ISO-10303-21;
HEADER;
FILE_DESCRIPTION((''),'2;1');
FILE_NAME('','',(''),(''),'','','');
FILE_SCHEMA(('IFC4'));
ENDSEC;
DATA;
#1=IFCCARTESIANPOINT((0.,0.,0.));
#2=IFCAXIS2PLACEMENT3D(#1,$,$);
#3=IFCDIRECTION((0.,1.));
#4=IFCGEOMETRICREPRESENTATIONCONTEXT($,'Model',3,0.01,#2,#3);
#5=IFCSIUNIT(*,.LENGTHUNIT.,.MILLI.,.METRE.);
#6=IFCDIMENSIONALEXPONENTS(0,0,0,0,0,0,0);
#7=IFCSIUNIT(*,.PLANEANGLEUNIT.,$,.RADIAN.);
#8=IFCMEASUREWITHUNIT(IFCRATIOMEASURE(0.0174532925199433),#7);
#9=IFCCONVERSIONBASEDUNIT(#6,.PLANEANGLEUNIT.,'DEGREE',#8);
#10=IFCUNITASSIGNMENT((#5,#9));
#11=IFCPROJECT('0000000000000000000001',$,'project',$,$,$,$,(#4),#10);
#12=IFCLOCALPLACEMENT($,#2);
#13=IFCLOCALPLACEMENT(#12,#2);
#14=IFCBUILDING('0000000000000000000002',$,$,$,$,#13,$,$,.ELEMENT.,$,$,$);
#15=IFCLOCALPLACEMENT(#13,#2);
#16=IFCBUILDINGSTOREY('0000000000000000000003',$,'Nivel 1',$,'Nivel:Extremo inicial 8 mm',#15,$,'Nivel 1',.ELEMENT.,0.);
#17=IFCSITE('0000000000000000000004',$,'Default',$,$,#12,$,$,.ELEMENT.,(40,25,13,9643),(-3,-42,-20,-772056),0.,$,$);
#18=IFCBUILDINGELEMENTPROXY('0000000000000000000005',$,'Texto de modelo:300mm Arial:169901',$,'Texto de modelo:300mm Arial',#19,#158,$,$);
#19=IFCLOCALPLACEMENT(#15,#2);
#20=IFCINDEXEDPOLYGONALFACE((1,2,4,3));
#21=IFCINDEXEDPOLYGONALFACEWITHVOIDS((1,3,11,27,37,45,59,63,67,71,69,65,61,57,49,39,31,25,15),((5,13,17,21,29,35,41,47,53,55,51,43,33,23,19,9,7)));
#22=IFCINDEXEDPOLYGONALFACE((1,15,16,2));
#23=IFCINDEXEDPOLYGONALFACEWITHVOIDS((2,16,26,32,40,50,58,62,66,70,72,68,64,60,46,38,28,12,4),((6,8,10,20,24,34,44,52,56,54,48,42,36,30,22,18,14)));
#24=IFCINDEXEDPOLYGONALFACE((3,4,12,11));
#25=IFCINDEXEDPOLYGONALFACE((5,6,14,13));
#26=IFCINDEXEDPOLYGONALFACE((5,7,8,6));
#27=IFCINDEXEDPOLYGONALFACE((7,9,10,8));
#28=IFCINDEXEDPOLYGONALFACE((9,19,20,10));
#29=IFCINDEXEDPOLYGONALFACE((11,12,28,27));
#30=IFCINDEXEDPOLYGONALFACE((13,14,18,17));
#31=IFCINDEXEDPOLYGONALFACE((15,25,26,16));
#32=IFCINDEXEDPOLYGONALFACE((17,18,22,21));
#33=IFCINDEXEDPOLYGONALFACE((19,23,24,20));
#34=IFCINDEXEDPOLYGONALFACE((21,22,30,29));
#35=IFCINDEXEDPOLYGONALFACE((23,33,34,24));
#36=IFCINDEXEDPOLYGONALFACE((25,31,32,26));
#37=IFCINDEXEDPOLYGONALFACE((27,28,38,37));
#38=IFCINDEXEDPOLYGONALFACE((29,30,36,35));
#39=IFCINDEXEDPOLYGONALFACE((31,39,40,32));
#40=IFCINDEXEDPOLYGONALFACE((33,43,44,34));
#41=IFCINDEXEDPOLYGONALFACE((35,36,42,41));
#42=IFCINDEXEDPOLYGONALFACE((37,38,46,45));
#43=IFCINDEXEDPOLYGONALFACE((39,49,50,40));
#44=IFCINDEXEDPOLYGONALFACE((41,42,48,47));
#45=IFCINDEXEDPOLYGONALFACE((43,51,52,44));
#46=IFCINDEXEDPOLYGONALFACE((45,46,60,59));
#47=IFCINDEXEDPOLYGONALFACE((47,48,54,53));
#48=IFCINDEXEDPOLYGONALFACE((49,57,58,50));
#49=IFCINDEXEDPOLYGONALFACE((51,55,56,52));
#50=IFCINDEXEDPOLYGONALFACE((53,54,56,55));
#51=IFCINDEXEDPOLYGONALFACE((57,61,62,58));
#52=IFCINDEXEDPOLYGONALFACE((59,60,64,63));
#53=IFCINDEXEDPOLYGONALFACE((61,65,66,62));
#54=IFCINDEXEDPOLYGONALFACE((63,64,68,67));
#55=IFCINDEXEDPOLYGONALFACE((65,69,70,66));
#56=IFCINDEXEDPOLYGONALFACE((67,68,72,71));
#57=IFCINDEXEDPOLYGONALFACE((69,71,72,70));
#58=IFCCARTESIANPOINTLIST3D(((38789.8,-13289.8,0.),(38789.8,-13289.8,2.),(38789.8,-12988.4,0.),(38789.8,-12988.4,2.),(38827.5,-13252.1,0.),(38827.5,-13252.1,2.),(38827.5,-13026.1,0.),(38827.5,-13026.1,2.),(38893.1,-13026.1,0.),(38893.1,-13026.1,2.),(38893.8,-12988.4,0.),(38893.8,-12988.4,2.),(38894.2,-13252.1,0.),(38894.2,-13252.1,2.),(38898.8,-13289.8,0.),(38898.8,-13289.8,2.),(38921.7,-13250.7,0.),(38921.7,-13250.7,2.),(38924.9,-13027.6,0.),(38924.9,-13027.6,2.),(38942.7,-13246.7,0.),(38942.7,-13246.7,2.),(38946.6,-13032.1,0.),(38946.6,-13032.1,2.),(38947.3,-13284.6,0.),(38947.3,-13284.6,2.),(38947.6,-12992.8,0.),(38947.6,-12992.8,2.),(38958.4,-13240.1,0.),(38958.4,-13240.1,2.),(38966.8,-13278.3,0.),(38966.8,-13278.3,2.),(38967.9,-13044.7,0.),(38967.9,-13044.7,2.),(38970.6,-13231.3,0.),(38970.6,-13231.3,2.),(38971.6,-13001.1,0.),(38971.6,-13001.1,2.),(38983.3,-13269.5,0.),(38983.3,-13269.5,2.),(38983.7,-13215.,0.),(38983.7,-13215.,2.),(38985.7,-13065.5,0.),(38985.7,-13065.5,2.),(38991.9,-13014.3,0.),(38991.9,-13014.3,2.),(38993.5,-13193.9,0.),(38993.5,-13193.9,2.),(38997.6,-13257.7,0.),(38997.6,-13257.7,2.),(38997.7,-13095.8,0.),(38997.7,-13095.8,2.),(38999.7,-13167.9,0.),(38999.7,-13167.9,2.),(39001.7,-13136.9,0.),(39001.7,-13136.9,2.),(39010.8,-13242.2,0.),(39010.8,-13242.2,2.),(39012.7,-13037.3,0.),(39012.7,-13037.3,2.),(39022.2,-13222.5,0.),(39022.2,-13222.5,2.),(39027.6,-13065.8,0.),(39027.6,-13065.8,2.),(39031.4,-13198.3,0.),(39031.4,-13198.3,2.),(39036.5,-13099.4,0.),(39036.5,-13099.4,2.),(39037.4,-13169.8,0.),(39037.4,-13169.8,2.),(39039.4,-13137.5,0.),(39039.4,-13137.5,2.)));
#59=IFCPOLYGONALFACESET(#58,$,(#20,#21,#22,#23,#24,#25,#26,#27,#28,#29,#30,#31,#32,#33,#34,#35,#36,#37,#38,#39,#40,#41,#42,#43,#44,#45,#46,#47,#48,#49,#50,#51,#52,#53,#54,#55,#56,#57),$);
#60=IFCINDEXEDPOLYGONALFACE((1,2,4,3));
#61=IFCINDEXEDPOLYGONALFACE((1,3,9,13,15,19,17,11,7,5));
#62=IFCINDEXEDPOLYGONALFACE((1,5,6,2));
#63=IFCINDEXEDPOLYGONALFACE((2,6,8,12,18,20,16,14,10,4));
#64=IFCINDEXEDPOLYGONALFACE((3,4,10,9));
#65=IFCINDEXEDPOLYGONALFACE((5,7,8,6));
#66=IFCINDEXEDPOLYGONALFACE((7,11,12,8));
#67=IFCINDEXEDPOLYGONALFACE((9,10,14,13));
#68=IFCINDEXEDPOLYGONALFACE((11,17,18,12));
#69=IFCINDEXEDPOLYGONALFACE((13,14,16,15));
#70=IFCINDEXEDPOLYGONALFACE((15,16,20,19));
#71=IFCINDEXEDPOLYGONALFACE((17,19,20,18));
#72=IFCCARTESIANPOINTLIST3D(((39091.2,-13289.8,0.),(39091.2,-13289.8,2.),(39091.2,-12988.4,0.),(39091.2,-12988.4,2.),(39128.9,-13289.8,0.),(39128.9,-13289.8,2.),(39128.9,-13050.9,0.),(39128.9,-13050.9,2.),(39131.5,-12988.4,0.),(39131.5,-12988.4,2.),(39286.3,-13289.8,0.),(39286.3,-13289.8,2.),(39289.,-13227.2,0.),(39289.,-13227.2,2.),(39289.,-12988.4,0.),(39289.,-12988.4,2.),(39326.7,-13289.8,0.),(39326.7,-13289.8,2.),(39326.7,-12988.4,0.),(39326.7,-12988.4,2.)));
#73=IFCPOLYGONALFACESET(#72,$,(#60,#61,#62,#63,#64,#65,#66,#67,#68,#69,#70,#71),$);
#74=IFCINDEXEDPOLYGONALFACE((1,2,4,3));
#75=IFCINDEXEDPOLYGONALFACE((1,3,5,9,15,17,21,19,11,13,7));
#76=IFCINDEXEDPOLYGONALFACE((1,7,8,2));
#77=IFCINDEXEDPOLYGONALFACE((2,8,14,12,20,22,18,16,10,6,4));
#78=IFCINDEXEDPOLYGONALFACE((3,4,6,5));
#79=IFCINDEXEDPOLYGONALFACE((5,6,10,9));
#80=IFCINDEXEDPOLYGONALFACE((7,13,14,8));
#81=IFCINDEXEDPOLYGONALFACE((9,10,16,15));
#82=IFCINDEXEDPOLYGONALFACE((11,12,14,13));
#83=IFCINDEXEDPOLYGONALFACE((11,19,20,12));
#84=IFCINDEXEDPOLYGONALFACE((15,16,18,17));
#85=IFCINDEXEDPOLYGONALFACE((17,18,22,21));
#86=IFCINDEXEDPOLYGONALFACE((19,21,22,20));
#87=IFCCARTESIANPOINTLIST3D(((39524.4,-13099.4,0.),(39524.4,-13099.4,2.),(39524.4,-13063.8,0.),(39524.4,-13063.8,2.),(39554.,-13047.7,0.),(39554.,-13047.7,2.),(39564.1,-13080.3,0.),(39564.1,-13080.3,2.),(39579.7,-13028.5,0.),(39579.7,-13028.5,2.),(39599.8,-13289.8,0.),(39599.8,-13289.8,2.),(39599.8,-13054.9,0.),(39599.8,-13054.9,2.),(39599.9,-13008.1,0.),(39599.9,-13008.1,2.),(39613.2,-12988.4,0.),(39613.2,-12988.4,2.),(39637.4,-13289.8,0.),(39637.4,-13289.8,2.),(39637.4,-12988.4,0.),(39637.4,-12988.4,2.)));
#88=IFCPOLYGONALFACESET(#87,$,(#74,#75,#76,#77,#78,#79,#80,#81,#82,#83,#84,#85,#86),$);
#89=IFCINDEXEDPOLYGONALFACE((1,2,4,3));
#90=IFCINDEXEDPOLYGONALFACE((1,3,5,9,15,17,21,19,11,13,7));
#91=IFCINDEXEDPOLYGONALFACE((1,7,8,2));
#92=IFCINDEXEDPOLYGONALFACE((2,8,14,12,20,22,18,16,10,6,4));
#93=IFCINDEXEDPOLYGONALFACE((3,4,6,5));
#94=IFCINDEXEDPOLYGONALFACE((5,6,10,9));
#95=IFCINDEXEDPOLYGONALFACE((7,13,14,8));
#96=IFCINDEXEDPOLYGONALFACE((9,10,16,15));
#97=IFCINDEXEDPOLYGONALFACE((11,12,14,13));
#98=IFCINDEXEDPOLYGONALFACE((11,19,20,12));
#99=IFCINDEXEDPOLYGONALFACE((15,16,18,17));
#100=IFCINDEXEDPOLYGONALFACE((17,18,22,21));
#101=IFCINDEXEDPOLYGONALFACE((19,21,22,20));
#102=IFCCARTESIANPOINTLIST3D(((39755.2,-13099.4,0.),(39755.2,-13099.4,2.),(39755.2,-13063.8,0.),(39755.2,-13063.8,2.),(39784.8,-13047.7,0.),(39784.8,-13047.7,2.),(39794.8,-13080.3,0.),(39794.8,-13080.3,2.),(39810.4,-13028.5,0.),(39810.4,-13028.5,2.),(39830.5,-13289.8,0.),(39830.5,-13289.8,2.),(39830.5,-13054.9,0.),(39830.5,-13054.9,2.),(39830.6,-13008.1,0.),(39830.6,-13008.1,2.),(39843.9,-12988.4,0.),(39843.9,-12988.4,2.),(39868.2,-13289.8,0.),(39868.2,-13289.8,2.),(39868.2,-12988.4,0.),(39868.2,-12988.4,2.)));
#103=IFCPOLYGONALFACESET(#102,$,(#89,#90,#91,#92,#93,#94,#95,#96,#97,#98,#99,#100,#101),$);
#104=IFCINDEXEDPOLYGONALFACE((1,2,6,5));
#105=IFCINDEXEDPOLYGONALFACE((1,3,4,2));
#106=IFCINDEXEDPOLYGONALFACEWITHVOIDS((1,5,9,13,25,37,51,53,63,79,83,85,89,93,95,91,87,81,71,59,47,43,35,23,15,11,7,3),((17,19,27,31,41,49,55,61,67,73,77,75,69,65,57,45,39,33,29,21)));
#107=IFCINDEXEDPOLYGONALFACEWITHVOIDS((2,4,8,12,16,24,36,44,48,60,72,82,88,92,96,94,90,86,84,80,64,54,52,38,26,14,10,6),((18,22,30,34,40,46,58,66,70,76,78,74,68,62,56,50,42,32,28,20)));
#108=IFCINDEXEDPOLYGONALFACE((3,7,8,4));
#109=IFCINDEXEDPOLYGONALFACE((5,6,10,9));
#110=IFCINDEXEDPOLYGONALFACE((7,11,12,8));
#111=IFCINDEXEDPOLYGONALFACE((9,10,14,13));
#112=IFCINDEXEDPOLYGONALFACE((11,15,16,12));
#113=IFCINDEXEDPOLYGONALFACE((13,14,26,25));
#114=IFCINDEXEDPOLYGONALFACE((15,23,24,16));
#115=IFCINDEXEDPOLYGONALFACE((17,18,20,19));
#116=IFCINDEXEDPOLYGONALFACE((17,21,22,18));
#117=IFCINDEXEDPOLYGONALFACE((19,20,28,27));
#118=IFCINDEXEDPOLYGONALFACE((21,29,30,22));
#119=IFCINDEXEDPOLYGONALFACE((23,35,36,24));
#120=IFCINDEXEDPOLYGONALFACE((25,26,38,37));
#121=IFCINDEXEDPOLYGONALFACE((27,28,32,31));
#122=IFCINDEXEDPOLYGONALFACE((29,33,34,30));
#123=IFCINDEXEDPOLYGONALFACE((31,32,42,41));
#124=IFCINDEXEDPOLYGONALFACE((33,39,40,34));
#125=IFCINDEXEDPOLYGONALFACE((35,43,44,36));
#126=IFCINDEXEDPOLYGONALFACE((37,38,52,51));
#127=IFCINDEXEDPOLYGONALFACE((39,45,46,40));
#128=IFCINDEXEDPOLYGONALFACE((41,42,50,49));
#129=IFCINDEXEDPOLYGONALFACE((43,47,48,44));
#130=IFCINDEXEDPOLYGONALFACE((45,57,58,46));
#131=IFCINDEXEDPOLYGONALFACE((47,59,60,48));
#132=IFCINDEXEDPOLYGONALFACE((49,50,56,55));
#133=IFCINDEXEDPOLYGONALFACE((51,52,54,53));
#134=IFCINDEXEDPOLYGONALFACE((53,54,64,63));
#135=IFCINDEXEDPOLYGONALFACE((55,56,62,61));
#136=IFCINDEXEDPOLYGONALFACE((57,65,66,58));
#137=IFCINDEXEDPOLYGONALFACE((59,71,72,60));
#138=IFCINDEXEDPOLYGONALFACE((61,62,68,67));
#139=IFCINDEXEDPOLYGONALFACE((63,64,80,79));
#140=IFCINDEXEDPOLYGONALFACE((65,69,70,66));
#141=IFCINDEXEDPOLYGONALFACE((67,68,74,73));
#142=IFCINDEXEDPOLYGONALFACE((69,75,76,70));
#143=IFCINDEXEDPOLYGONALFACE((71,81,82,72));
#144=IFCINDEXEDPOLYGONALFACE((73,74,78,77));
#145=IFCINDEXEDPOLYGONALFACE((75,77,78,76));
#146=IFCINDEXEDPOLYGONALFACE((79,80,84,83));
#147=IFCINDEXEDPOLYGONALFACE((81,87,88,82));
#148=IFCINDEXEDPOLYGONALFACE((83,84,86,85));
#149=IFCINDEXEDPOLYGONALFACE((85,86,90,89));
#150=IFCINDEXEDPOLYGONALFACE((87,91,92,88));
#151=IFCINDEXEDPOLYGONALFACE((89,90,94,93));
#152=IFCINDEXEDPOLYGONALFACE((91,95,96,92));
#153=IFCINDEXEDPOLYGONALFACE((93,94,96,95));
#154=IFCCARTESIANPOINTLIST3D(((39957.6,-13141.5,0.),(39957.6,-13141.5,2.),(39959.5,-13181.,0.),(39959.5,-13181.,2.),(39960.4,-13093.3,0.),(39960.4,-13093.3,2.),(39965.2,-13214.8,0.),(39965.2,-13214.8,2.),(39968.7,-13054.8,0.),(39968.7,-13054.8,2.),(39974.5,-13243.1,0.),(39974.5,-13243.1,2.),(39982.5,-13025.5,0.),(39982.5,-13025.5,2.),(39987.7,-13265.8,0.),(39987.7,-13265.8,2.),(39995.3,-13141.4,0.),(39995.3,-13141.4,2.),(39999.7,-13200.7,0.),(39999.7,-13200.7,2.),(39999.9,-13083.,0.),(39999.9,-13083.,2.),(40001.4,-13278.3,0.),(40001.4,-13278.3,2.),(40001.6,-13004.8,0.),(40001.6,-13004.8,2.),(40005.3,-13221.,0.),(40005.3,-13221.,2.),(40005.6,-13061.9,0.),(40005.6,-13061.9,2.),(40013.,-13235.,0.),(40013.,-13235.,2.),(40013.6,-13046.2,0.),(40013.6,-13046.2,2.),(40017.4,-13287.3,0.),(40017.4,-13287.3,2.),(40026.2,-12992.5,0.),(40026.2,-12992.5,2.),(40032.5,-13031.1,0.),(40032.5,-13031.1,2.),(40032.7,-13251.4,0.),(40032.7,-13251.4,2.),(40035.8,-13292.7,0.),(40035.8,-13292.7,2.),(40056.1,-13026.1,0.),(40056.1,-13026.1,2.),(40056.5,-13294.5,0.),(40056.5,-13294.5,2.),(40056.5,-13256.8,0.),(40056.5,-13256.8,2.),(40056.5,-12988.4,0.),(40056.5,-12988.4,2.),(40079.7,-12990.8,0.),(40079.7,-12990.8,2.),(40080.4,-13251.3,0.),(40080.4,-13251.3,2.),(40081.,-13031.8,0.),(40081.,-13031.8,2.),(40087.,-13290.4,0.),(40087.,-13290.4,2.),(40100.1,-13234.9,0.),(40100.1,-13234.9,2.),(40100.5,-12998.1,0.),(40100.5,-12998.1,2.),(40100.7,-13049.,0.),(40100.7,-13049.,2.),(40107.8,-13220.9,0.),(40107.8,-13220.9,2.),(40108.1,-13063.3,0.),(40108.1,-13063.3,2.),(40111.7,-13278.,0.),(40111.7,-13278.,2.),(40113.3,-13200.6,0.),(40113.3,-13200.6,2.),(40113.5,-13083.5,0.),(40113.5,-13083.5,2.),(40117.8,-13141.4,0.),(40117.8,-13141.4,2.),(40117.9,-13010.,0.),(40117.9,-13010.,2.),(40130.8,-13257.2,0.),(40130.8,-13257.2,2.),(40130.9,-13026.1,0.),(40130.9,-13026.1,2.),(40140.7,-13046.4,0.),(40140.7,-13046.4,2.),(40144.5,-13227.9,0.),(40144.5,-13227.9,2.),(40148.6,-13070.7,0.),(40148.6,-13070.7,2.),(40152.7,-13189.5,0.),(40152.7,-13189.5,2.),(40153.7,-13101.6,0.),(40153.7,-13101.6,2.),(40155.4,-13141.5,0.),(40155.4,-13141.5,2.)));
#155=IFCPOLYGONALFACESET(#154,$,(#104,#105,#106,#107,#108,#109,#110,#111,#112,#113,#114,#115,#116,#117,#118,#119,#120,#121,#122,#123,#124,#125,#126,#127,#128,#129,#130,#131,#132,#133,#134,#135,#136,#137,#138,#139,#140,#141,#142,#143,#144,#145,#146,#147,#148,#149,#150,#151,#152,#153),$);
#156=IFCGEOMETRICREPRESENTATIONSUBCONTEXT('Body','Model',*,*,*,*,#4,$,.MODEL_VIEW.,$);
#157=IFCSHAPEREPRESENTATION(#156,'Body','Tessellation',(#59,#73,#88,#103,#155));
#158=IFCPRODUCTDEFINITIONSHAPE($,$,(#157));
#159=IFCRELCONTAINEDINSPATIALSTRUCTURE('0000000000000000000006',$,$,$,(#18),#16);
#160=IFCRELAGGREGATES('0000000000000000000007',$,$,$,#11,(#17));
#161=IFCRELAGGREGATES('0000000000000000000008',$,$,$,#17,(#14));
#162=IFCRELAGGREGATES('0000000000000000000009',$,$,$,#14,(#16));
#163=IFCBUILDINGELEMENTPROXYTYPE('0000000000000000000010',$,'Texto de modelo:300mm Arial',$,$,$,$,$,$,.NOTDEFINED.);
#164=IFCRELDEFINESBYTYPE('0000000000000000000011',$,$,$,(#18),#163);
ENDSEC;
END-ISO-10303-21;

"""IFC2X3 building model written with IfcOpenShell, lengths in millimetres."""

from ifc_helpers import new_model, entity, si_unit, converted_unit, direction, frame, origin, place, context, subcontext, project, spatial, polyline, outline, extrude, type_object, element, save


model = new_model("IFC2X3")

# Units and contexts
model_context = context("Model", 3, precision=0.01, world=origin(), true_north=direction((0.0, 1.0)))
body_context = subcontext(model_context, "Body", "Model", "MODEL_VIEW")
ifc_project = project(units=[si_unit("LENGTHUNIT", "METRE", prefix="MILLI"), converted_unit("PLANEANGLEUNIT", "DEGREE", entity("IfcRatioMeasure", 0.0174532925199433), si_unit("PLANEANGLEUNIT", "RADIAN"), dimensions=[0, 0, 0, 0, 0, 0, 0])], contexts=[model_context])

# Site, building, storey
site_placement = place(None, origin())
site = spatial("IfcSite", under=ifc_project, at=site_placement, Name="Default", CompositionType="ELEMENT", RefLatitude=(40, 25, 13, 9643), RefLongitude=(-3, -42, -20, -772056), RefElevation=0.0)
building_placement = place(site_placement, origin())
building = spatial("IfcBuilding", under=site, at=building_placement, CompositionType="ELEMENT")
storey_placement = place(building_placement, origin())
storey = spatial("IfcBuildingStorey", under=building, at=storey_placement, Name="Nivel 1", ObjectType="Nivel:Extremo inicial 8 mm", LongName="Nivel 1", CompositionType="ELEMENT", Elevation=0.0)

# Building element proxy
building_element_proxy_type_1 = type_object("IfcBuildingElementProxyType", Name="Texto de modelo:300mm Arial", PredefinedType="NOTDEFINED")
proxy_1_placement = place(storey_placement, frame((38789.8, -13294.5, 0.0)))
element("IfcBuildingElementProxy", 1, at=proxy_1_placement, inside=storey, type_object=building_element_proxy_type_1, Name="Texto de modelo:300mm Arial:169901", ObjectType="Texto de modelo:300mm Arial", context=body_context, shape_type="SweptSolid", body=[
    extrude(outline(polyline([(-178.4, -141.0), (-69.4, -141.0), (-21.0, -135.8), (-1.4, -129.5), (15.0, -120.7), (29.4, -108.9), (42.6, -93.4), (54.0, -73.7), (63.2, -49.5), (69.2, -21.0), (71.2, 11.3), (68.2, 49.4), (59.3, 83.0), (44.5, 111.5), (23.7, 134.5), (3.4, 147.7), (-20.6, 156.1), (-74.4, 160.4), (-178.4, 160.4), (-178.4, -141.0)]), holes=[polyline([(-140.7, -103.3), (-140.7, 122.7), (-75.1, 122.7), (-43.3, 121.2), (-21.7, 116.7), (-0.4, 104.1), (17.4, 83.3), (29.5, 53.0), (33.5, 11.9), (31.5, -19.1), (25.3, -45.1), (15.5, -66.2), (2.4, -82.5), (-9.8, -91.3), (-25.6, -97.9), (-46.5, -101.9), (-74.1, -103.3), (-140.7, -103.3)])]), frame((178.4, 145.7, 0.0)), (0.0, 0.0, 1.0), 2.0),
    extrude(outline(polyline([(-117.7, -150.7), (-80.1, -150.7), (-80.1, 88.1), (77.4, -150.7), (117.7, -150.7), (117.7, 150.7), (80.1, 150.7), (80.1, -88.1), (-77.4, 150.7), (-117.7, 150.7), (-117.7, -150.7)])), frame((419.1, 155.4, 0.0)), (0.0, 0.0, 1.0), 2.0),
    extrude(outline(polyline([(-204.4, -52.5), (97.0, -52.5), (97.0, -28.2), (77.2, -14.9), (56.9, 5.3), (37.7, 30.9), (21.6, 60.5), (-14.0, 60.5), (5.0, 20.8), (30.4, -14.9), (-204.4, -14.9), (-204.4, -52.5)])), frame((795.1, 209.1, 0.0), z_axis=(0.0, 0.0, 1.0), x_axis=(0.0, 1.0, 0.0)), (0.0, 0.0, 1.0), 2.0),
    extrude(outline(polyline([(-204.4, -52.5), (97.0, -52.5), (97.0, -28.2), (77.2, -14.9), (56.9, 5.3), (37.7, 30.9), (21.6, 60.5), (-14.0, 60.5), (5.0, 20.8), (30.4, -14.9), (-204.4, -14.9), (-204.4, -52.5)])), frame((1025.8, 209.1, 0.0), z_axis=(0.0, 0.0, 1.0), x_axis=(0.0, 1.0, 0.0)), (0.0, 0.0, 1.0), 2.0),
    extrude(outline(polyline([(-5.6, -99.5), (33.9, -99.5), (68.0, -95.5), (96.7, -87.5), (120.0, -75.5), (133.2, -62.4), (142.9, -46.8), (149.1, -28.7), (151.9, -8.0), (149.2, 22.6), (138.0, 47.8), (118.2, 67.9), (89.5, 82.9), (51.6, 93.0), (3.8, 98.0), (-36.2, 98.2), (-67.3, 94.5), (-91.9, 87.9), (-112.6, 79.0), (-129.4, 66.8), (-142.0, 50.0), (-150.3, 29.6), (-153.8, 6.5), (-151.2, -23.9), (-140.1, -49.1), (-120.3, -69.2), (-91.7, -84.4), (-53.6, -94.5), (-5.6, -99.5)]), holes=[polyline([(-3.9, -61.9), (-62.1, -54.6), (-82.9, -47.9), (-98.1, -39.2), (-112.3, -19.5), (-116.2, 4.3), (-109.3, 28.9), (-91.2, 47.7), (-76.5, 54.5), (-56.1, 58.9), (1.9, 60.4), (60.8, 53.2), (80.8, 46.7), (94.5, 38.3), (109.9, 17.8), (114.3, -6.3), (107.7, -29.8), (90.4, -48.7), (76.0, -55.8), (55.5, -60.3), (-3.9, -61.9)])]), frame((1267.5, 152.1, 0.0), z_axis=(0.0, 0.0, 1.0), x_axis=(0.047515, -0.998871, 0.0)), (0.0, 0.0, 1.0), 2.0),
])

save(model, "model.ifc")
